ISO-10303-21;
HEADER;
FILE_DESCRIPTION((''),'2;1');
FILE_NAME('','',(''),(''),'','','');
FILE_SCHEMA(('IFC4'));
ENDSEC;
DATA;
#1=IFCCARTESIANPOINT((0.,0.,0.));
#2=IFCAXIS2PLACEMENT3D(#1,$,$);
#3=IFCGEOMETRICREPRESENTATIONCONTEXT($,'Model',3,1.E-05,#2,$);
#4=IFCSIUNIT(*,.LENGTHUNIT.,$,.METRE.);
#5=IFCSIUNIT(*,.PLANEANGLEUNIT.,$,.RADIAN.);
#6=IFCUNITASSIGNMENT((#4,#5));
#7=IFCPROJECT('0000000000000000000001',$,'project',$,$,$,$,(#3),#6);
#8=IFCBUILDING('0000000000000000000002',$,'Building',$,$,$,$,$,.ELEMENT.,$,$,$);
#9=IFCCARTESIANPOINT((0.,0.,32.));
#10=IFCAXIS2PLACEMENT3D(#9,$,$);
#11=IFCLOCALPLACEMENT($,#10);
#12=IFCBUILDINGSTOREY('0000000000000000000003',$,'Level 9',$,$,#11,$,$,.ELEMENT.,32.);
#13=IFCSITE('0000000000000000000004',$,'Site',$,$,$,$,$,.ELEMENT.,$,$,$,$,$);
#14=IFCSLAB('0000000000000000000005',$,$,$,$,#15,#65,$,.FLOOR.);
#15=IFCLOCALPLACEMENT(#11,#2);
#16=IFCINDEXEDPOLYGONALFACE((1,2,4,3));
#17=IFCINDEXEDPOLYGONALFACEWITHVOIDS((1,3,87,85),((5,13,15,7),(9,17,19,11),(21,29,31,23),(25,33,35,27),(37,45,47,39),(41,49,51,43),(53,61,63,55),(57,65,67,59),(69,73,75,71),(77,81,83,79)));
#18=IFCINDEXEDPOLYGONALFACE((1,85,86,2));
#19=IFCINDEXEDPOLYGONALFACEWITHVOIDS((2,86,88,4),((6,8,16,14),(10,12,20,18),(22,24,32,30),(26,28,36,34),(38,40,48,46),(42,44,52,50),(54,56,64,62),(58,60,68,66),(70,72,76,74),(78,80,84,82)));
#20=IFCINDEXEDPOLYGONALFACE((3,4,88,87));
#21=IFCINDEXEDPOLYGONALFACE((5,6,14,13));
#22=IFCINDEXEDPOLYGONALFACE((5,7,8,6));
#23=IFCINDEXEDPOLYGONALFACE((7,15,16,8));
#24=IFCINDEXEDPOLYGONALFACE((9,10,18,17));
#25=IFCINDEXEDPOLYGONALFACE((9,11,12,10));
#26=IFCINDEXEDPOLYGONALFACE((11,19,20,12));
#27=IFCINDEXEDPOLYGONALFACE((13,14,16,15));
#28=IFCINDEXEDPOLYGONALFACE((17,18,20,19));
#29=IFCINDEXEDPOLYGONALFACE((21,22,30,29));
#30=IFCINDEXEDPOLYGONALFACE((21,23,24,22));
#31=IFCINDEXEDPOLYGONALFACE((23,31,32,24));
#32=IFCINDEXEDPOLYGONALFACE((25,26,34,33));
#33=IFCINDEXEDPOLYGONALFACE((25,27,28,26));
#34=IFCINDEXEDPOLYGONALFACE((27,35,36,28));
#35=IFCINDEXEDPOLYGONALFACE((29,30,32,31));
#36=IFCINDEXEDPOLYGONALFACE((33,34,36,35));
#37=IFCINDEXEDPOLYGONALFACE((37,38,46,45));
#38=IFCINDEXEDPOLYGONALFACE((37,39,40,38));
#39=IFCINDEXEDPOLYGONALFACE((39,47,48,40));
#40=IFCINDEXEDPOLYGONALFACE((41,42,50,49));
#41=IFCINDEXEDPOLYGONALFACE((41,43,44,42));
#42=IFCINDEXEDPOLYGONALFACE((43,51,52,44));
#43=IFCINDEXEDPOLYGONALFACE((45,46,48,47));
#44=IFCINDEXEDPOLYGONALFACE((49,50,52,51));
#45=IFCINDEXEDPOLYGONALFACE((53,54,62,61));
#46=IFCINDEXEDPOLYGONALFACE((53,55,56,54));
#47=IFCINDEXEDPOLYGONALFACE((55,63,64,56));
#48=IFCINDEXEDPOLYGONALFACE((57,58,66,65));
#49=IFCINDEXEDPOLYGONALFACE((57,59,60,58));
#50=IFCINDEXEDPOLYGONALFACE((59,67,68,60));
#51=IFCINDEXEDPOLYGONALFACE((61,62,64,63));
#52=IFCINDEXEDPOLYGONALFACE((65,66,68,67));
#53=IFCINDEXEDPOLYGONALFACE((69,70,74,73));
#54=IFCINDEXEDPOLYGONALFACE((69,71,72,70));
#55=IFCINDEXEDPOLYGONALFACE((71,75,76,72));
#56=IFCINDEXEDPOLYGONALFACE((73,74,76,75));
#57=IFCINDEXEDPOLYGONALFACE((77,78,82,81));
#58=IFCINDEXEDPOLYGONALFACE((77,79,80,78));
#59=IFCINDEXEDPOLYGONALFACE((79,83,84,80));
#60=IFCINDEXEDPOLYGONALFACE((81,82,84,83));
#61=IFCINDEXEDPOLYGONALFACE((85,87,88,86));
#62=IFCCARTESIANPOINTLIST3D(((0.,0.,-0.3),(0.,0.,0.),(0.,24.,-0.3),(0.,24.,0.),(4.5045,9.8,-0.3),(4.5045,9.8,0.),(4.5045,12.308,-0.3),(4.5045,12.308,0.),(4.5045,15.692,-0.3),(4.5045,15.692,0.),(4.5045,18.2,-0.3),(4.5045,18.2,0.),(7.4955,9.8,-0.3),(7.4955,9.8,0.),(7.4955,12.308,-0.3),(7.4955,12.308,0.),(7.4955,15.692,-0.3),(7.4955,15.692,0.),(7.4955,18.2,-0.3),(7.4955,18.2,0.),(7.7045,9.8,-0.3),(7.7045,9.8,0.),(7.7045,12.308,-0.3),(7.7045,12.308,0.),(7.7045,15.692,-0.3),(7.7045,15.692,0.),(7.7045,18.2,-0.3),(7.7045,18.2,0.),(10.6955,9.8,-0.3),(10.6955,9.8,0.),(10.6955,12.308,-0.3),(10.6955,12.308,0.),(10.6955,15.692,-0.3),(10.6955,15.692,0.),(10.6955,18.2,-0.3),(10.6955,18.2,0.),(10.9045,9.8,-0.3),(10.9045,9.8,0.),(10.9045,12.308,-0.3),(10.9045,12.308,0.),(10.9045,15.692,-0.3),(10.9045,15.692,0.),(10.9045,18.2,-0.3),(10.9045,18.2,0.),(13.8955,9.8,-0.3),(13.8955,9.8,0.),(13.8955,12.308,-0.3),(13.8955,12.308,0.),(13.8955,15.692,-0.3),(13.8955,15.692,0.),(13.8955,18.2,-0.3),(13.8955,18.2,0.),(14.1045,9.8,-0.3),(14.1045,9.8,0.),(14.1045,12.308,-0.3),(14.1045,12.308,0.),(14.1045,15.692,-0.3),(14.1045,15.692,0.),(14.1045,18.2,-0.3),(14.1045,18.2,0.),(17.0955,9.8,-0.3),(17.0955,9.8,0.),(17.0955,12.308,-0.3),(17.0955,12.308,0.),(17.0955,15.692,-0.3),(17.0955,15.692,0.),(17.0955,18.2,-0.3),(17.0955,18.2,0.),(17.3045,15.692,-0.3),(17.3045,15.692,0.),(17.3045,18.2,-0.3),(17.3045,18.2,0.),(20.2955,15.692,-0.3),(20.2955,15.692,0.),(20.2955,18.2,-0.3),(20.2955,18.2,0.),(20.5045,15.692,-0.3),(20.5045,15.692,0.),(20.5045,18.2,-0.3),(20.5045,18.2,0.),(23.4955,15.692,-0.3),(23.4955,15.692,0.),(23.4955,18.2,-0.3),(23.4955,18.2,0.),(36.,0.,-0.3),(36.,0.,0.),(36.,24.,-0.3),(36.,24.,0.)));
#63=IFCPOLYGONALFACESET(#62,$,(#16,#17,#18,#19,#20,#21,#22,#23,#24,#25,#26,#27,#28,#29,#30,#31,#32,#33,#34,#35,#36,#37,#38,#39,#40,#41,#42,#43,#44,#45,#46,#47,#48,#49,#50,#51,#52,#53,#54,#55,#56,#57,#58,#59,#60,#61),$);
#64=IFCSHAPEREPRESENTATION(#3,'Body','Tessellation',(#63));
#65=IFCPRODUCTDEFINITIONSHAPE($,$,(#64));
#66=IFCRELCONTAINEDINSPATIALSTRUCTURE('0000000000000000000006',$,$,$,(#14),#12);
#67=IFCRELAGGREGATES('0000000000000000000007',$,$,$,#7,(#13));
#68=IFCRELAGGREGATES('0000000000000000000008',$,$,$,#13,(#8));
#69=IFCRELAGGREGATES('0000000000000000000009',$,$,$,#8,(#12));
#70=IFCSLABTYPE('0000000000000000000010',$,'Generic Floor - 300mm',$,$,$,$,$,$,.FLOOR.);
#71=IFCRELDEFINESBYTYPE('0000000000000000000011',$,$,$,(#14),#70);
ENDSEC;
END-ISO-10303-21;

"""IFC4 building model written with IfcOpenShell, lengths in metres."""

from ifc_helpers import new_model, si_unit, frame, origin, place, context, project, spatial, polyline, outline, extrude, type_object, element, save


model = new_model("IFC4")

# Units and contexts
model_context = context("Model", 3, precision=1e-05, world=origin())
ifc_project = project(units=[si_unit("LENGTHUNIT", "METRE"), si_unit("PLANEANGLEUNIT", "RADIAN")], contexts=[model_context])

# Site, building, storey
site = spatial("IfcSite", under=ifc_project, Name="Site", CompositionType="ELEMENT")
building = spatial("IfcBuilding", under=site, Name="Building", CompositionType="ELEMENT")
storey_placement = place(None, frame((0.0, 0.0, 32.0)))
storey = spatial("IfcBuildingStorey", under=building, at=storey_placement, Name="Level 9", CompositionType="ELEMENT", Elevation=32.0)

# Slab, openings
slab_type = type_object("IfcSlabType", Name="Generic Floor - 300mm", PredefinedType="FLOOR")
slab_placement = place(None, frame((0.0, 0.0, 32.0)))
slab = element("IfcSlab", 1, at=slab_placement, inside=storey, type_object=slab_type, PredefinedType="FLOOR", context=model_context, shape_type="SweptSolid", body=[
    extrude(outline(polyline([(0.0, 0.0), (36.0, 0.0), (36.0, 24.0), (0.0, 24.0), (0.0, 0.0)])), origin(), (0.0, 0.0, -1.0), 0.3),
])
opening_1_placement = place(None, frame((0.0, 0.0, 32.001)))
element("IfcOpeningElement", 2, at=opening_1_placement, cuts=slab, PredefinedType="OPENING", context=model_context, shape_type="SweptSolid", body=[
    extrude(outline(polyline([(4.5045, 9.8), (7.4955, 9.8), (7.4955, 12.308), (4.5045, 12.308), (4.5045, 9.8)])), origin(), (0.0, 0.0, -1.0), 0.302),
])
opening_2_placement = place(None, frame((0.0, 0.0, 32.001)))
element("IfcOpeningElement", 3, at=opening_2_placement, cuts=slab, PredefinedType="OPENING", context=model_context, shape_type="SweptSolid", body=[
    extrude(outline(polyline([(7.7045, 9.8), (10.6955, 9.8), (10.6955, 12.308), (7.7045, 12.308), (7.7045, 9.8)])), origin(), (0.0, 0.0, -1.0), 0.302),
])
opening_3_placement = place(None, frame((0.0, 0.0, 32.001)))
element("IfcOpeningElement", 4, at=opening_3_placement, cuts=slab, PredefinedType="OPENING", context=model_context, shape_type="SweptSolid", body=[
    extrude(outline(polyline([(10.9045, 9.8), (13.8955, 9.8), (13.8955, 12.308), (10.9045, 12.308), (10.9045, 9.8)])), origin(), (0.0, 0.0, -1.0), 0.302),
])
opening_4_placement = place(None, frame((0.0, 0.0, 32.001)))
element("IfcOpeningElement", 5, at=opening_4_placement, cuts=slab, PredefinedType="OPENING", context=model_context, shape_type="SweptSolid", body=[
    extrude(outline(polyline([(14.1045, 9.8), (17.0955, 9.8), (17.0955, 12.308), (14.1045, 12.308), (14.1045, 9.8)])), origin(), (0.0, 0.0, -1.0), 0.302),
])
opening_5_placement = place(None, frame((0.0, 0.0, 32.001)))
element("IfcOpeningElement", 6, at=opening_5_placement, cuts=slab, PredefinedType="OPENING", context=model_context, shape_type="SweptSolid", body=[
    extrude(outline(polyline([(7.4955, 18.2), (4.5045, 18.2), (4.5045, 15.692), (7.4955, 15.692), (7.4955, 18.2)])), origin(), (0.0, 0.0, -1.0), 0.302),
])
opening_6_placement = place(None, frame((0.0, 0.0, 32.001)))
element("IfcOpeningElement", 7, at=opening_6_placement, cuts=slab, PredefinedType="OPENING", context=model_context, shape_type="SweptSolid", body=[
    extrude(outline(polyline([(10.6955, 18.2), (7.7045, 18.2), (7.7045, 15.692), (10.6955, 15.692), (10.6955, 18.2)])), origin(), (0.0, 0.0, -1.0), 0.302),
])
opening_7_placement = place(None, frame((0.0, 0.0, 32.001)))
element("IfcOpeningElement", 8, at=opening_7_placement, cuts=slab, PredefinedType="OPENING", context=model_context, shape_type="SweptSolid", body=[
    extrude(outline(polyline([(13.8955, 18.2), (10.9045, 18.2), (10.9045, 15.692), (13.8955, 15.692), (13.8955, 18.2)])), origin(), (0.0, 0.0, -1.0), 0.302),
])
opening_8_placement = place(None, frame((0.0, 0.0, 32.001)))
element("IfcOpeningElement", 9, at=opening_8_placement, cuts=slab, PredefinedType="OPENING", context=model_context, shape_type="SweptSolid", body=[
    extrude(outline(polyline([(17.0955, 18.2), (14.1045, 18.2), (14.1045, 15.692), (17.0955, 15.692), (17.0955, 18.2)])), origin(), (0.0, 0.0, -1.0), 0.302),
])
opening_9_placement = place(None, frame((0.0, 0.0, 32.001)))
element("IfcOpeningElement", 10, at=opening_9_placement, cuts=slab, PredefinedType="OPENING", context=model_context, shape_type="SweptSolid", body=[
    extrude(outline(polyline([(20.2955, 18.2), (17.3045, 18.2), (17.3045, 15.692), (20.2955, 15.692), (20.2955, 18.2)])), origin(), (0.0, 0.0, -1.0), 0.302),
])
opening_10_placement = place(None, frame((0.0, 0.0, 32.001)))
element("IfcOpeningElement", 11, at=opening_10_placement, cuts=slab, PredefinedType="OPENING", context=model_context, shape_type="SweptSolid", body=[
    extrude(outline(polyline([(23.4955, 18.2), (20.5045, 18.2), (20.5045, 15.692), (23.4955, 15.692), (23.4955, 18.2)])), origin(), (0.0, 0.0, -1.0), 0.302),
])

save(model, "model.ifc")
